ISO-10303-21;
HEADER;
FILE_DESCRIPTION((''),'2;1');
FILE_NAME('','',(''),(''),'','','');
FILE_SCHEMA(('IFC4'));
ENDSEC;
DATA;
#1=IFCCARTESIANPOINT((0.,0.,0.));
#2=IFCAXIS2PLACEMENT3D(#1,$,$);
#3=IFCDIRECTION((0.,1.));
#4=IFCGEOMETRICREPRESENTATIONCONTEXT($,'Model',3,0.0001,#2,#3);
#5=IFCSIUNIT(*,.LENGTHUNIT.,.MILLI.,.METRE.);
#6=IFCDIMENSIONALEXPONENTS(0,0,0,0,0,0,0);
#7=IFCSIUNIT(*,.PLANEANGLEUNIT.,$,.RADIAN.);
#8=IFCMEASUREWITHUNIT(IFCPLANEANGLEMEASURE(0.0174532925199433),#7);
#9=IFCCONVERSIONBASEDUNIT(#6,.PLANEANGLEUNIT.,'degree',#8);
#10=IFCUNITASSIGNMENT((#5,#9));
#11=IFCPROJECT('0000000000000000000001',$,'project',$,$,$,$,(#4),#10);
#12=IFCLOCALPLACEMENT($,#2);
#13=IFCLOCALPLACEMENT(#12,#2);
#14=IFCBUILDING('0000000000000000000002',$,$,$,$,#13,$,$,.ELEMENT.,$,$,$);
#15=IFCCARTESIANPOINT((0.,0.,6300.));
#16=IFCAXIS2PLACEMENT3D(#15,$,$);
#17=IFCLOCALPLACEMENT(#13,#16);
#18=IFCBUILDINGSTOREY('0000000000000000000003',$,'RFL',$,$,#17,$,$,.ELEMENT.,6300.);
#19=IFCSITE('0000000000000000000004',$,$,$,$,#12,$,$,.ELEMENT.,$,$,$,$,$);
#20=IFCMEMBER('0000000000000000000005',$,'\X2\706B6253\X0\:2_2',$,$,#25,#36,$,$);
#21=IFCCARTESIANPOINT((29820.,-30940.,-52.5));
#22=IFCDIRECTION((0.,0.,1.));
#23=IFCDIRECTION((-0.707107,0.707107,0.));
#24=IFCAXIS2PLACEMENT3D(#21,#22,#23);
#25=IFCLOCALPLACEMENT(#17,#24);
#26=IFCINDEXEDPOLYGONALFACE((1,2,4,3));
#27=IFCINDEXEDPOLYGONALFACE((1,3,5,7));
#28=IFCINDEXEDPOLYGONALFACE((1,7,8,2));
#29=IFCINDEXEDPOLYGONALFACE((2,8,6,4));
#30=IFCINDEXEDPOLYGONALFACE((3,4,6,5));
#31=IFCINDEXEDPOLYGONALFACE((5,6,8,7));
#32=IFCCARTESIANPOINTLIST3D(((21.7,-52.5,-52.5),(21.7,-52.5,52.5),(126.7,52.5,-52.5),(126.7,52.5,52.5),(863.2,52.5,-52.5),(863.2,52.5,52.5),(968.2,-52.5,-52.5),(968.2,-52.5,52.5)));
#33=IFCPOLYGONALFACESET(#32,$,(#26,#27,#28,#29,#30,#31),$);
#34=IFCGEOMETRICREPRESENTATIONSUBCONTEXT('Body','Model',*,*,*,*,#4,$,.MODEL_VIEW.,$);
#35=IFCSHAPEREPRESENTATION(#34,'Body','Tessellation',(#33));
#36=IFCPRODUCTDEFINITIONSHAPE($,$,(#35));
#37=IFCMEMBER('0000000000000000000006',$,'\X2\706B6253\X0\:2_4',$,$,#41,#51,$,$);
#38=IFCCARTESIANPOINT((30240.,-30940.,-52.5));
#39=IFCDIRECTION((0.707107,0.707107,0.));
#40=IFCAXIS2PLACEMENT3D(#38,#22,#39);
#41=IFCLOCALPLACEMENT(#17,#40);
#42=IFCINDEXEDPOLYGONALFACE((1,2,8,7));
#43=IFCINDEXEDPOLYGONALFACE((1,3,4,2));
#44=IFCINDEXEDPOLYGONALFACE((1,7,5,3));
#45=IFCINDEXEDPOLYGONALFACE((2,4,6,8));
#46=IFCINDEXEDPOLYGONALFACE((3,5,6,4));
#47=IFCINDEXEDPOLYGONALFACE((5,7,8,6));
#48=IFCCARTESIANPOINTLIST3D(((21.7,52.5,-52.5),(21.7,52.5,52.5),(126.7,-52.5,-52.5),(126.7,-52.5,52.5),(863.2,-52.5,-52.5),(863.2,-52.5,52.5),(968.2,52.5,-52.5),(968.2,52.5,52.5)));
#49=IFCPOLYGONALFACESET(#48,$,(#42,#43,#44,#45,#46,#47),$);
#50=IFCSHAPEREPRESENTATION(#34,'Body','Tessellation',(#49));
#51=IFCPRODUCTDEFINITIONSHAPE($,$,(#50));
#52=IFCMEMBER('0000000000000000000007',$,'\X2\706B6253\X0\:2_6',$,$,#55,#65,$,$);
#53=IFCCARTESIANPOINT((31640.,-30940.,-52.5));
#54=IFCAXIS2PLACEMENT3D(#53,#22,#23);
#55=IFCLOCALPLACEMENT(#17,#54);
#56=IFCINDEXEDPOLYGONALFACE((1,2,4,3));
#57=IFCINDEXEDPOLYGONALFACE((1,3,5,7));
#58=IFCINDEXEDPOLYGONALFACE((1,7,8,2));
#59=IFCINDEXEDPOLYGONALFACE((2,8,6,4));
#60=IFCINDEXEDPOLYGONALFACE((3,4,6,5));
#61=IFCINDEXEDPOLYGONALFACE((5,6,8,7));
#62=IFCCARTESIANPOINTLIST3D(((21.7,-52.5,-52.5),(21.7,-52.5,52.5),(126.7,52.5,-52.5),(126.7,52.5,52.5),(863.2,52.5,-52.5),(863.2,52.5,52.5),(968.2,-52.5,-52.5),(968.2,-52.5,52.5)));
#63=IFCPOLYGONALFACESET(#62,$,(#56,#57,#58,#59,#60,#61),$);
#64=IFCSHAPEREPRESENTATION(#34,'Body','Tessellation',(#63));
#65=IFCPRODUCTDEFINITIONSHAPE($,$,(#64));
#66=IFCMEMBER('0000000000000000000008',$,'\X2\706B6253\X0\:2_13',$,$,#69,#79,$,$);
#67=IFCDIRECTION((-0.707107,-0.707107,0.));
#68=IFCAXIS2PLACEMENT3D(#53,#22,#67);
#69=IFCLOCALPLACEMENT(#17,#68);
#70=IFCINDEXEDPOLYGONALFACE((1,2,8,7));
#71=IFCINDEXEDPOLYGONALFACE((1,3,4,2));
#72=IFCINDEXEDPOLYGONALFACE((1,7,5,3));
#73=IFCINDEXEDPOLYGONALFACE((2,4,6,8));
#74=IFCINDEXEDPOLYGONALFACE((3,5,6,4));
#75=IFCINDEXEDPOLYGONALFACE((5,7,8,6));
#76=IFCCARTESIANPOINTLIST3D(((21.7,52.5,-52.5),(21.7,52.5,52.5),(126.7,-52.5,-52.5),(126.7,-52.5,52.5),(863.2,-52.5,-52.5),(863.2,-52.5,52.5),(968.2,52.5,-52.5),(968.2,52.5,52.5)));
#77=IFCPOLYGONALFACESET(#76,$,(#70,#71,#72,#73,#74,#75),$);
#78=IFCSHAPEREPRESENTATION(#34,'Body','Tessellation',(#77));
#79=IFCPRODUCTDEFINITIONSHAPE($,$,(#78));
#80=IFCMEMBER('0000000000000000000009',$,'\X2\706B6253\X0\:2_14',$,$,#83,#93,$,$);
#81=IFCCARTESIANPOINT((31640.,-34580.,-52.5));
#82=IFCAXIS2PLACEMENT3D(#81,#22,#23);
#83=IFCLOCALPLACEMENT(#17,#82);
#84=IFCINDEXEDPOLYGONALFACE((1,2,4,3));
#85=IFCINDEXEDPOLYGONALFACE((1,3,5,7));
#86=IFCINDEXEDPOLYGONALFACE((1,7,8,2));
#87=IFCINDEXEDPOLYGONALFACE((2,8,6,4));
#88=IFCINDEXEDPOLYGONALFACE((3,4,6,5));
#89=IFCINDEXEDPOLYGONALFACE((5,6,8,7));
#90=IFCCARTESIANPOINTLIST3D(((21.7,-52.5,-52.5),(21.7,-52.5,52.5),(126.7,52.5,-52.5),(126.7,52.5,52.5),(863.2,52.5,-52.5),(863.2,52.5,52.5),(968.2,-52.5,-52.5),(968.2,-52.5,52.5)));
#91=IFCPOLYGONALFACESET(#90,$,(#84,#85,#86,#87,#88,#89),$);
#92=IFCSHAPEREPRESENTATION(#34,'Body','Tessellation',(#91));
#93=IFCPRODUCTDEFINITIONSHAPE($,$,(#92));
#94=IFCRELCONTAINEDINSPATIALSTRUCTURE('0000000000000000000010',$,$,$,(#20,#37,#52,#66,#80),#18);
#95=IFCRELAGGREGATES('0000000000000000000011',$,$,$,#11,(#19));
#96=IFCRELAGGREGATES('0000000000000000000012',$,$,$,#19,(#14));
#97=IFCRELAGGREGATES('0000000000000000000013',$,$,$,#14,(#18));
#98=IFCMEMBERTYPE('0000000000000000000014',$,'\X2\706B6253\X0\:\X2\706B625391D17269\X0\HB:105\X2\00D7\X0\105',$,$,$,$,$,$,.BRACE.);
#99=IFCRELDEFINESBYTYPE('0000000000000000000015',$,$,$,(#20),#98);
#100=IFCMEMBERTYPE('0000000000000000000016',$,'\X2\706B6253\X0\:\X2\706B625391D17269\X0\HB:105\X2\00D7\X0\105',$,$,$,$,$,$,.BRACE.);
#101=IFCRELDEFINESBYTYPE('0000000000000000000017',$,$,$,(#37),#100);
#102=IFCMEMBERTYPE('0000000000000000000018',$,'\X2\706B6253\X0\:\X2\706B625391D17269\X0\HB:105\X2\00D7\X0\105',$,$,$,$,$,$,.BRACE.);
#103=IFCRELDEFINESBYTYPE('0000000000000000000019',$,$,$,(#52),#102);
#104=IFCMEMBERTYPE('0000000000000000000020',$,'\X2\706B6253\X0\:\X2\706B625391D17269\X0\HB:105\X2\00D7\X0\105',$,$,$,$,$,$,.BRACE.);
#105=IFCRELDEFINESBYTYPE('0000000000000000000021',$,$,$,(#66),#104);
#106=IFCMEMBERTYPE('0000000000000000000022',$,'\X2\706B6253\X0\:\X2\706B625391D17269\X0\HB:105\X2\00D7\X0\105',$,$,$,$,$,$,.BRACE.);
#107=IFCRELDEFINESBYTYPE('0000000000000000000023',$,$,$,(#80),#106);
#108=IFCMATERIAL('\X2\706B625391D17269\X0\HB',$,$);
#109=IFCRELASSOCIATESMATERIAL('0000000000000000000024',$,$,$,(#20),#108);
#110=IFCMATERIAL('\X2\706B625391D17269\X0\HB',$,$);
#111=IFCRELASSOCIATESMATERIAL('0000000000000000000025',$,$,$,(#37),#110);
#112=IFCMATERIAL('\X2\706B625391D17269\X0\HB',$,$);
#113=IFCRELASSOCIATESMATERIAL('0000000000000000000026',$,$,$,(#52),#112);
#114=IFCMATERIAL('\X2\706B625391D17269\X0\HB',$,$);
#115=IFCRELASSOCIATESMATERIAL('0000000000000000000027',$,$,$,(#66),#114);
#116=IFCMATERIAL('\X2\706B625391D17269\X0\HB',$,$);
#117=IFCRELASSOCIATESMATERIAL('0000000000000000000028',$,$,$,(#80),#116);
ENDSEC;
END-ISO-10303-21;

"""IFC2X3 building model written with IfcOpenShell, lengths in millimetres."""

from ifc_helpers import new_model, entity, si_unit, converted_unit, direction, frame, origin, place, context, subcontext, project, spatial, polyline, outline, extrude, material, type_object, element, save


model = new_model("IFC2X3")

# Units and contexts
model_context = context("Model", 3, precision=0.0001, world=origin(), true_north=direction((0.0, 1.0)))
body_context = subcontext(model_context, "Body", "Model", "MODEL_VIEW")
ifc_project = project(units=[si_unit("LENGTHUNIT", "METRE", prefix="MILLI"), converted_unit("PLANEANGLEUNIT", "degree", entity("IfcPlaneAngleMeasure", 0.0174532925199433), si_unit("PLANEANGLEUNIT", "RADIAN"), dimensions=[0, 0, 0, 0, 0, 0, 0])], contexts=[model_context])

# Site, building, storey
site_placement = place(None, origin())
site = spatial("IfcSite", under=ifc_project, at=site_placement, CompositionType="ELEMENT")
building_placement = place(site_placement, origin())
building = spatial("IfcBuilding", under=site, at=building_placement, CompositionType="ELEMENT")
storey_placement = place(building_placement, frame((0.0, 0.0, 6300.0)))
storey = spatial("IfcBuildingStorey", under=building, at=storey_placement, Name="RFL", CompositionType="ELEMENT", Elevation=6300.0)

# Members
ifc_material_1 = material(Name="火打金物HB")
member_type_1 = type_object("IfcMemberType", Name="火打:火打金物HB:105×105", PredefinedType="BRACE")
member_1_placement = place(storey_placement, frame((29820.0, -30940.0, -52.5), z_axis=(0.0, 0.0, 1.0), x_axis=(-0.707107, 0.707107, 0.0)))
element("IfcMember", 1, at=member_1_placement, inside=storey, type_object=member_type_1, material=ifc_material_1, Name="火打:2_2", context=body_context, shape_type="SweptSolid", body=[
    extrude(outline(polyline([(21.7, -52.5, 0.0), (126.7, 52.5, 0.0), (863.2, 52.5, 0.0), (968.2, -52.5, 0.0), (21.7, -52.5, 0.0)])), frame((0.0, 0.0, -52.5), z_axis=(0.0, 0.0, 1.0), x_axis=(1.0, 0.0, 0.0)), (0.0, 0.0, 1.0), 105.0),
])
ifc_material_2 = material(Name="火打金物HB")
member_type_2 = type_object("IfcMemberType", Name="火打:火打金物HB:105×105", PredefinedType="BRACE")
member_2_placement = place(storey_placement, frame((30240.0, -30940.0, -52.5), z_axis=(0.0, 0.0, 1.0), x_axis=(0.707107, 0.707107, 0.0)))
element("IfcMember", 2, at=member_2_placement, inside=storey, type_object=member_type_2, material=ifc_material_2, Name="火打:2_4", context=body_context, shape_type="SweptSolid", body=[
    extrude(outline(polyline([(126.7, -52.5, 0.0), (21.7, 52.5, 0.0), (968.2, 52.5, 0.0), (863.2, -52.5, 0.0), (126.7, -52.5, 0.0)])), frame((0.0, 0.0, -52.5), z_axis=(0.0, 0.0, 1.0), x_axis=(1.0, 0.0, 0.0)), (0.0, 0.0, 1.0), 105.0),
])
ifc_material_3 = material(Name="火打金物HB")
member_type_3 = type_object("IfcMemberType", Name="火打:火打金物HB:105×105", PredefinedType="BRACE")
member_3_placement = place(storey_placement, frame((31640.0, -30940.0, -52.5), z_axis=(0.0, 0.0, 1.0), x_axis=(-0.707107, 0.707107, 0.0)))
element("IfcMember", 3, at=member_3_placement, inside=storey, type_object=member_type_3, material=ifc_material_3, Name="火打:2_6", context=body_context, shape_type="SweptSolid", body=[
    extrude(outline(polyline([(21.7, -52.5, 0.0), (126.7, 52.5, 0.0), (863.2, 52.5, 0.0), (968.2, -52.5, 0.0), (21.7, -52.5, 0.0)])), frame((0.0, 0.0, -52.5), z_axis=(0.0, 0.0, 1.0), x_axis=(1.0, 0.0, 0.0)), (0.0, 0.0, 1.0), 105.0),
])
ifc_material_4 = material(Name="火打金物HB")
member_type_4 = type_object("IfcMemberType", Name="火打:火打金物HB:105×105", PredefinedType="BRACE")
member_4_placement = place(storey_placement, frame((31640.0, -30940.0, -52.5), z_axis=(0.0, 0.0, 1.0), x_axis=(-0.707107, -0.707107, 0.0)))
element("IfcMember", 4, at=member_4_placement, inside=storey, type_object=member_type_4, material=ifc_material_4, Name="火打:2_13", context=body_context, shape_type="SweptSolid", body=[
    extrude(outline(polyline([(126.7, -52.5, 0.0), (21.7, 52.5, 0.0), (968.2, 52.5, 0.0), (863.2, -52.5, 0.0), (126.7, -52.5, 0.0)])), frame((0.0, 0.0, -52.5), z_axis=(0.0, 0.0, 1.0), x_axis=(1.0, 0.0, 0.0)), (0.0, 0.0, 1.0), 105.0),
])
ifc_material_5 = material(Name="火打金物HB")
member_type_5 = type_object("IfcMemberType", Name="火打:火打金物HB:105×105", PredefinedType="BRACE")
member_5_placement = place(storey_placement, frame((31640.0, -34580.0, -52.5), z_axis=(0.0, 0.0, 1.0), x_axis=(-0.707107, 0.707107, 0.0)))
element("IfcMember", 5, at=member_5_placement, inside=storey, type_object=member_type_5, material=ifc_material_5, Name="火打:2_14", context=body_context, shape_type="SweptSolid", body=[
    extrude(outline(polyline([(21.7, -52.5, 0.0), (126.7, 52.5, 0.0), (863.2, 52.5, 0.0), (968.2, -52.5, 0.0), (21.7, -52.5, 0.0)])), frame((0.0, 0.0, -52.5), z_axis=(0.0, 0.0, 1.0), x_axis=(1.0, 0.0, 0.0)), (0.0, 0.0, 1.0), 105.0),
])

save(model, "model.ifc")
